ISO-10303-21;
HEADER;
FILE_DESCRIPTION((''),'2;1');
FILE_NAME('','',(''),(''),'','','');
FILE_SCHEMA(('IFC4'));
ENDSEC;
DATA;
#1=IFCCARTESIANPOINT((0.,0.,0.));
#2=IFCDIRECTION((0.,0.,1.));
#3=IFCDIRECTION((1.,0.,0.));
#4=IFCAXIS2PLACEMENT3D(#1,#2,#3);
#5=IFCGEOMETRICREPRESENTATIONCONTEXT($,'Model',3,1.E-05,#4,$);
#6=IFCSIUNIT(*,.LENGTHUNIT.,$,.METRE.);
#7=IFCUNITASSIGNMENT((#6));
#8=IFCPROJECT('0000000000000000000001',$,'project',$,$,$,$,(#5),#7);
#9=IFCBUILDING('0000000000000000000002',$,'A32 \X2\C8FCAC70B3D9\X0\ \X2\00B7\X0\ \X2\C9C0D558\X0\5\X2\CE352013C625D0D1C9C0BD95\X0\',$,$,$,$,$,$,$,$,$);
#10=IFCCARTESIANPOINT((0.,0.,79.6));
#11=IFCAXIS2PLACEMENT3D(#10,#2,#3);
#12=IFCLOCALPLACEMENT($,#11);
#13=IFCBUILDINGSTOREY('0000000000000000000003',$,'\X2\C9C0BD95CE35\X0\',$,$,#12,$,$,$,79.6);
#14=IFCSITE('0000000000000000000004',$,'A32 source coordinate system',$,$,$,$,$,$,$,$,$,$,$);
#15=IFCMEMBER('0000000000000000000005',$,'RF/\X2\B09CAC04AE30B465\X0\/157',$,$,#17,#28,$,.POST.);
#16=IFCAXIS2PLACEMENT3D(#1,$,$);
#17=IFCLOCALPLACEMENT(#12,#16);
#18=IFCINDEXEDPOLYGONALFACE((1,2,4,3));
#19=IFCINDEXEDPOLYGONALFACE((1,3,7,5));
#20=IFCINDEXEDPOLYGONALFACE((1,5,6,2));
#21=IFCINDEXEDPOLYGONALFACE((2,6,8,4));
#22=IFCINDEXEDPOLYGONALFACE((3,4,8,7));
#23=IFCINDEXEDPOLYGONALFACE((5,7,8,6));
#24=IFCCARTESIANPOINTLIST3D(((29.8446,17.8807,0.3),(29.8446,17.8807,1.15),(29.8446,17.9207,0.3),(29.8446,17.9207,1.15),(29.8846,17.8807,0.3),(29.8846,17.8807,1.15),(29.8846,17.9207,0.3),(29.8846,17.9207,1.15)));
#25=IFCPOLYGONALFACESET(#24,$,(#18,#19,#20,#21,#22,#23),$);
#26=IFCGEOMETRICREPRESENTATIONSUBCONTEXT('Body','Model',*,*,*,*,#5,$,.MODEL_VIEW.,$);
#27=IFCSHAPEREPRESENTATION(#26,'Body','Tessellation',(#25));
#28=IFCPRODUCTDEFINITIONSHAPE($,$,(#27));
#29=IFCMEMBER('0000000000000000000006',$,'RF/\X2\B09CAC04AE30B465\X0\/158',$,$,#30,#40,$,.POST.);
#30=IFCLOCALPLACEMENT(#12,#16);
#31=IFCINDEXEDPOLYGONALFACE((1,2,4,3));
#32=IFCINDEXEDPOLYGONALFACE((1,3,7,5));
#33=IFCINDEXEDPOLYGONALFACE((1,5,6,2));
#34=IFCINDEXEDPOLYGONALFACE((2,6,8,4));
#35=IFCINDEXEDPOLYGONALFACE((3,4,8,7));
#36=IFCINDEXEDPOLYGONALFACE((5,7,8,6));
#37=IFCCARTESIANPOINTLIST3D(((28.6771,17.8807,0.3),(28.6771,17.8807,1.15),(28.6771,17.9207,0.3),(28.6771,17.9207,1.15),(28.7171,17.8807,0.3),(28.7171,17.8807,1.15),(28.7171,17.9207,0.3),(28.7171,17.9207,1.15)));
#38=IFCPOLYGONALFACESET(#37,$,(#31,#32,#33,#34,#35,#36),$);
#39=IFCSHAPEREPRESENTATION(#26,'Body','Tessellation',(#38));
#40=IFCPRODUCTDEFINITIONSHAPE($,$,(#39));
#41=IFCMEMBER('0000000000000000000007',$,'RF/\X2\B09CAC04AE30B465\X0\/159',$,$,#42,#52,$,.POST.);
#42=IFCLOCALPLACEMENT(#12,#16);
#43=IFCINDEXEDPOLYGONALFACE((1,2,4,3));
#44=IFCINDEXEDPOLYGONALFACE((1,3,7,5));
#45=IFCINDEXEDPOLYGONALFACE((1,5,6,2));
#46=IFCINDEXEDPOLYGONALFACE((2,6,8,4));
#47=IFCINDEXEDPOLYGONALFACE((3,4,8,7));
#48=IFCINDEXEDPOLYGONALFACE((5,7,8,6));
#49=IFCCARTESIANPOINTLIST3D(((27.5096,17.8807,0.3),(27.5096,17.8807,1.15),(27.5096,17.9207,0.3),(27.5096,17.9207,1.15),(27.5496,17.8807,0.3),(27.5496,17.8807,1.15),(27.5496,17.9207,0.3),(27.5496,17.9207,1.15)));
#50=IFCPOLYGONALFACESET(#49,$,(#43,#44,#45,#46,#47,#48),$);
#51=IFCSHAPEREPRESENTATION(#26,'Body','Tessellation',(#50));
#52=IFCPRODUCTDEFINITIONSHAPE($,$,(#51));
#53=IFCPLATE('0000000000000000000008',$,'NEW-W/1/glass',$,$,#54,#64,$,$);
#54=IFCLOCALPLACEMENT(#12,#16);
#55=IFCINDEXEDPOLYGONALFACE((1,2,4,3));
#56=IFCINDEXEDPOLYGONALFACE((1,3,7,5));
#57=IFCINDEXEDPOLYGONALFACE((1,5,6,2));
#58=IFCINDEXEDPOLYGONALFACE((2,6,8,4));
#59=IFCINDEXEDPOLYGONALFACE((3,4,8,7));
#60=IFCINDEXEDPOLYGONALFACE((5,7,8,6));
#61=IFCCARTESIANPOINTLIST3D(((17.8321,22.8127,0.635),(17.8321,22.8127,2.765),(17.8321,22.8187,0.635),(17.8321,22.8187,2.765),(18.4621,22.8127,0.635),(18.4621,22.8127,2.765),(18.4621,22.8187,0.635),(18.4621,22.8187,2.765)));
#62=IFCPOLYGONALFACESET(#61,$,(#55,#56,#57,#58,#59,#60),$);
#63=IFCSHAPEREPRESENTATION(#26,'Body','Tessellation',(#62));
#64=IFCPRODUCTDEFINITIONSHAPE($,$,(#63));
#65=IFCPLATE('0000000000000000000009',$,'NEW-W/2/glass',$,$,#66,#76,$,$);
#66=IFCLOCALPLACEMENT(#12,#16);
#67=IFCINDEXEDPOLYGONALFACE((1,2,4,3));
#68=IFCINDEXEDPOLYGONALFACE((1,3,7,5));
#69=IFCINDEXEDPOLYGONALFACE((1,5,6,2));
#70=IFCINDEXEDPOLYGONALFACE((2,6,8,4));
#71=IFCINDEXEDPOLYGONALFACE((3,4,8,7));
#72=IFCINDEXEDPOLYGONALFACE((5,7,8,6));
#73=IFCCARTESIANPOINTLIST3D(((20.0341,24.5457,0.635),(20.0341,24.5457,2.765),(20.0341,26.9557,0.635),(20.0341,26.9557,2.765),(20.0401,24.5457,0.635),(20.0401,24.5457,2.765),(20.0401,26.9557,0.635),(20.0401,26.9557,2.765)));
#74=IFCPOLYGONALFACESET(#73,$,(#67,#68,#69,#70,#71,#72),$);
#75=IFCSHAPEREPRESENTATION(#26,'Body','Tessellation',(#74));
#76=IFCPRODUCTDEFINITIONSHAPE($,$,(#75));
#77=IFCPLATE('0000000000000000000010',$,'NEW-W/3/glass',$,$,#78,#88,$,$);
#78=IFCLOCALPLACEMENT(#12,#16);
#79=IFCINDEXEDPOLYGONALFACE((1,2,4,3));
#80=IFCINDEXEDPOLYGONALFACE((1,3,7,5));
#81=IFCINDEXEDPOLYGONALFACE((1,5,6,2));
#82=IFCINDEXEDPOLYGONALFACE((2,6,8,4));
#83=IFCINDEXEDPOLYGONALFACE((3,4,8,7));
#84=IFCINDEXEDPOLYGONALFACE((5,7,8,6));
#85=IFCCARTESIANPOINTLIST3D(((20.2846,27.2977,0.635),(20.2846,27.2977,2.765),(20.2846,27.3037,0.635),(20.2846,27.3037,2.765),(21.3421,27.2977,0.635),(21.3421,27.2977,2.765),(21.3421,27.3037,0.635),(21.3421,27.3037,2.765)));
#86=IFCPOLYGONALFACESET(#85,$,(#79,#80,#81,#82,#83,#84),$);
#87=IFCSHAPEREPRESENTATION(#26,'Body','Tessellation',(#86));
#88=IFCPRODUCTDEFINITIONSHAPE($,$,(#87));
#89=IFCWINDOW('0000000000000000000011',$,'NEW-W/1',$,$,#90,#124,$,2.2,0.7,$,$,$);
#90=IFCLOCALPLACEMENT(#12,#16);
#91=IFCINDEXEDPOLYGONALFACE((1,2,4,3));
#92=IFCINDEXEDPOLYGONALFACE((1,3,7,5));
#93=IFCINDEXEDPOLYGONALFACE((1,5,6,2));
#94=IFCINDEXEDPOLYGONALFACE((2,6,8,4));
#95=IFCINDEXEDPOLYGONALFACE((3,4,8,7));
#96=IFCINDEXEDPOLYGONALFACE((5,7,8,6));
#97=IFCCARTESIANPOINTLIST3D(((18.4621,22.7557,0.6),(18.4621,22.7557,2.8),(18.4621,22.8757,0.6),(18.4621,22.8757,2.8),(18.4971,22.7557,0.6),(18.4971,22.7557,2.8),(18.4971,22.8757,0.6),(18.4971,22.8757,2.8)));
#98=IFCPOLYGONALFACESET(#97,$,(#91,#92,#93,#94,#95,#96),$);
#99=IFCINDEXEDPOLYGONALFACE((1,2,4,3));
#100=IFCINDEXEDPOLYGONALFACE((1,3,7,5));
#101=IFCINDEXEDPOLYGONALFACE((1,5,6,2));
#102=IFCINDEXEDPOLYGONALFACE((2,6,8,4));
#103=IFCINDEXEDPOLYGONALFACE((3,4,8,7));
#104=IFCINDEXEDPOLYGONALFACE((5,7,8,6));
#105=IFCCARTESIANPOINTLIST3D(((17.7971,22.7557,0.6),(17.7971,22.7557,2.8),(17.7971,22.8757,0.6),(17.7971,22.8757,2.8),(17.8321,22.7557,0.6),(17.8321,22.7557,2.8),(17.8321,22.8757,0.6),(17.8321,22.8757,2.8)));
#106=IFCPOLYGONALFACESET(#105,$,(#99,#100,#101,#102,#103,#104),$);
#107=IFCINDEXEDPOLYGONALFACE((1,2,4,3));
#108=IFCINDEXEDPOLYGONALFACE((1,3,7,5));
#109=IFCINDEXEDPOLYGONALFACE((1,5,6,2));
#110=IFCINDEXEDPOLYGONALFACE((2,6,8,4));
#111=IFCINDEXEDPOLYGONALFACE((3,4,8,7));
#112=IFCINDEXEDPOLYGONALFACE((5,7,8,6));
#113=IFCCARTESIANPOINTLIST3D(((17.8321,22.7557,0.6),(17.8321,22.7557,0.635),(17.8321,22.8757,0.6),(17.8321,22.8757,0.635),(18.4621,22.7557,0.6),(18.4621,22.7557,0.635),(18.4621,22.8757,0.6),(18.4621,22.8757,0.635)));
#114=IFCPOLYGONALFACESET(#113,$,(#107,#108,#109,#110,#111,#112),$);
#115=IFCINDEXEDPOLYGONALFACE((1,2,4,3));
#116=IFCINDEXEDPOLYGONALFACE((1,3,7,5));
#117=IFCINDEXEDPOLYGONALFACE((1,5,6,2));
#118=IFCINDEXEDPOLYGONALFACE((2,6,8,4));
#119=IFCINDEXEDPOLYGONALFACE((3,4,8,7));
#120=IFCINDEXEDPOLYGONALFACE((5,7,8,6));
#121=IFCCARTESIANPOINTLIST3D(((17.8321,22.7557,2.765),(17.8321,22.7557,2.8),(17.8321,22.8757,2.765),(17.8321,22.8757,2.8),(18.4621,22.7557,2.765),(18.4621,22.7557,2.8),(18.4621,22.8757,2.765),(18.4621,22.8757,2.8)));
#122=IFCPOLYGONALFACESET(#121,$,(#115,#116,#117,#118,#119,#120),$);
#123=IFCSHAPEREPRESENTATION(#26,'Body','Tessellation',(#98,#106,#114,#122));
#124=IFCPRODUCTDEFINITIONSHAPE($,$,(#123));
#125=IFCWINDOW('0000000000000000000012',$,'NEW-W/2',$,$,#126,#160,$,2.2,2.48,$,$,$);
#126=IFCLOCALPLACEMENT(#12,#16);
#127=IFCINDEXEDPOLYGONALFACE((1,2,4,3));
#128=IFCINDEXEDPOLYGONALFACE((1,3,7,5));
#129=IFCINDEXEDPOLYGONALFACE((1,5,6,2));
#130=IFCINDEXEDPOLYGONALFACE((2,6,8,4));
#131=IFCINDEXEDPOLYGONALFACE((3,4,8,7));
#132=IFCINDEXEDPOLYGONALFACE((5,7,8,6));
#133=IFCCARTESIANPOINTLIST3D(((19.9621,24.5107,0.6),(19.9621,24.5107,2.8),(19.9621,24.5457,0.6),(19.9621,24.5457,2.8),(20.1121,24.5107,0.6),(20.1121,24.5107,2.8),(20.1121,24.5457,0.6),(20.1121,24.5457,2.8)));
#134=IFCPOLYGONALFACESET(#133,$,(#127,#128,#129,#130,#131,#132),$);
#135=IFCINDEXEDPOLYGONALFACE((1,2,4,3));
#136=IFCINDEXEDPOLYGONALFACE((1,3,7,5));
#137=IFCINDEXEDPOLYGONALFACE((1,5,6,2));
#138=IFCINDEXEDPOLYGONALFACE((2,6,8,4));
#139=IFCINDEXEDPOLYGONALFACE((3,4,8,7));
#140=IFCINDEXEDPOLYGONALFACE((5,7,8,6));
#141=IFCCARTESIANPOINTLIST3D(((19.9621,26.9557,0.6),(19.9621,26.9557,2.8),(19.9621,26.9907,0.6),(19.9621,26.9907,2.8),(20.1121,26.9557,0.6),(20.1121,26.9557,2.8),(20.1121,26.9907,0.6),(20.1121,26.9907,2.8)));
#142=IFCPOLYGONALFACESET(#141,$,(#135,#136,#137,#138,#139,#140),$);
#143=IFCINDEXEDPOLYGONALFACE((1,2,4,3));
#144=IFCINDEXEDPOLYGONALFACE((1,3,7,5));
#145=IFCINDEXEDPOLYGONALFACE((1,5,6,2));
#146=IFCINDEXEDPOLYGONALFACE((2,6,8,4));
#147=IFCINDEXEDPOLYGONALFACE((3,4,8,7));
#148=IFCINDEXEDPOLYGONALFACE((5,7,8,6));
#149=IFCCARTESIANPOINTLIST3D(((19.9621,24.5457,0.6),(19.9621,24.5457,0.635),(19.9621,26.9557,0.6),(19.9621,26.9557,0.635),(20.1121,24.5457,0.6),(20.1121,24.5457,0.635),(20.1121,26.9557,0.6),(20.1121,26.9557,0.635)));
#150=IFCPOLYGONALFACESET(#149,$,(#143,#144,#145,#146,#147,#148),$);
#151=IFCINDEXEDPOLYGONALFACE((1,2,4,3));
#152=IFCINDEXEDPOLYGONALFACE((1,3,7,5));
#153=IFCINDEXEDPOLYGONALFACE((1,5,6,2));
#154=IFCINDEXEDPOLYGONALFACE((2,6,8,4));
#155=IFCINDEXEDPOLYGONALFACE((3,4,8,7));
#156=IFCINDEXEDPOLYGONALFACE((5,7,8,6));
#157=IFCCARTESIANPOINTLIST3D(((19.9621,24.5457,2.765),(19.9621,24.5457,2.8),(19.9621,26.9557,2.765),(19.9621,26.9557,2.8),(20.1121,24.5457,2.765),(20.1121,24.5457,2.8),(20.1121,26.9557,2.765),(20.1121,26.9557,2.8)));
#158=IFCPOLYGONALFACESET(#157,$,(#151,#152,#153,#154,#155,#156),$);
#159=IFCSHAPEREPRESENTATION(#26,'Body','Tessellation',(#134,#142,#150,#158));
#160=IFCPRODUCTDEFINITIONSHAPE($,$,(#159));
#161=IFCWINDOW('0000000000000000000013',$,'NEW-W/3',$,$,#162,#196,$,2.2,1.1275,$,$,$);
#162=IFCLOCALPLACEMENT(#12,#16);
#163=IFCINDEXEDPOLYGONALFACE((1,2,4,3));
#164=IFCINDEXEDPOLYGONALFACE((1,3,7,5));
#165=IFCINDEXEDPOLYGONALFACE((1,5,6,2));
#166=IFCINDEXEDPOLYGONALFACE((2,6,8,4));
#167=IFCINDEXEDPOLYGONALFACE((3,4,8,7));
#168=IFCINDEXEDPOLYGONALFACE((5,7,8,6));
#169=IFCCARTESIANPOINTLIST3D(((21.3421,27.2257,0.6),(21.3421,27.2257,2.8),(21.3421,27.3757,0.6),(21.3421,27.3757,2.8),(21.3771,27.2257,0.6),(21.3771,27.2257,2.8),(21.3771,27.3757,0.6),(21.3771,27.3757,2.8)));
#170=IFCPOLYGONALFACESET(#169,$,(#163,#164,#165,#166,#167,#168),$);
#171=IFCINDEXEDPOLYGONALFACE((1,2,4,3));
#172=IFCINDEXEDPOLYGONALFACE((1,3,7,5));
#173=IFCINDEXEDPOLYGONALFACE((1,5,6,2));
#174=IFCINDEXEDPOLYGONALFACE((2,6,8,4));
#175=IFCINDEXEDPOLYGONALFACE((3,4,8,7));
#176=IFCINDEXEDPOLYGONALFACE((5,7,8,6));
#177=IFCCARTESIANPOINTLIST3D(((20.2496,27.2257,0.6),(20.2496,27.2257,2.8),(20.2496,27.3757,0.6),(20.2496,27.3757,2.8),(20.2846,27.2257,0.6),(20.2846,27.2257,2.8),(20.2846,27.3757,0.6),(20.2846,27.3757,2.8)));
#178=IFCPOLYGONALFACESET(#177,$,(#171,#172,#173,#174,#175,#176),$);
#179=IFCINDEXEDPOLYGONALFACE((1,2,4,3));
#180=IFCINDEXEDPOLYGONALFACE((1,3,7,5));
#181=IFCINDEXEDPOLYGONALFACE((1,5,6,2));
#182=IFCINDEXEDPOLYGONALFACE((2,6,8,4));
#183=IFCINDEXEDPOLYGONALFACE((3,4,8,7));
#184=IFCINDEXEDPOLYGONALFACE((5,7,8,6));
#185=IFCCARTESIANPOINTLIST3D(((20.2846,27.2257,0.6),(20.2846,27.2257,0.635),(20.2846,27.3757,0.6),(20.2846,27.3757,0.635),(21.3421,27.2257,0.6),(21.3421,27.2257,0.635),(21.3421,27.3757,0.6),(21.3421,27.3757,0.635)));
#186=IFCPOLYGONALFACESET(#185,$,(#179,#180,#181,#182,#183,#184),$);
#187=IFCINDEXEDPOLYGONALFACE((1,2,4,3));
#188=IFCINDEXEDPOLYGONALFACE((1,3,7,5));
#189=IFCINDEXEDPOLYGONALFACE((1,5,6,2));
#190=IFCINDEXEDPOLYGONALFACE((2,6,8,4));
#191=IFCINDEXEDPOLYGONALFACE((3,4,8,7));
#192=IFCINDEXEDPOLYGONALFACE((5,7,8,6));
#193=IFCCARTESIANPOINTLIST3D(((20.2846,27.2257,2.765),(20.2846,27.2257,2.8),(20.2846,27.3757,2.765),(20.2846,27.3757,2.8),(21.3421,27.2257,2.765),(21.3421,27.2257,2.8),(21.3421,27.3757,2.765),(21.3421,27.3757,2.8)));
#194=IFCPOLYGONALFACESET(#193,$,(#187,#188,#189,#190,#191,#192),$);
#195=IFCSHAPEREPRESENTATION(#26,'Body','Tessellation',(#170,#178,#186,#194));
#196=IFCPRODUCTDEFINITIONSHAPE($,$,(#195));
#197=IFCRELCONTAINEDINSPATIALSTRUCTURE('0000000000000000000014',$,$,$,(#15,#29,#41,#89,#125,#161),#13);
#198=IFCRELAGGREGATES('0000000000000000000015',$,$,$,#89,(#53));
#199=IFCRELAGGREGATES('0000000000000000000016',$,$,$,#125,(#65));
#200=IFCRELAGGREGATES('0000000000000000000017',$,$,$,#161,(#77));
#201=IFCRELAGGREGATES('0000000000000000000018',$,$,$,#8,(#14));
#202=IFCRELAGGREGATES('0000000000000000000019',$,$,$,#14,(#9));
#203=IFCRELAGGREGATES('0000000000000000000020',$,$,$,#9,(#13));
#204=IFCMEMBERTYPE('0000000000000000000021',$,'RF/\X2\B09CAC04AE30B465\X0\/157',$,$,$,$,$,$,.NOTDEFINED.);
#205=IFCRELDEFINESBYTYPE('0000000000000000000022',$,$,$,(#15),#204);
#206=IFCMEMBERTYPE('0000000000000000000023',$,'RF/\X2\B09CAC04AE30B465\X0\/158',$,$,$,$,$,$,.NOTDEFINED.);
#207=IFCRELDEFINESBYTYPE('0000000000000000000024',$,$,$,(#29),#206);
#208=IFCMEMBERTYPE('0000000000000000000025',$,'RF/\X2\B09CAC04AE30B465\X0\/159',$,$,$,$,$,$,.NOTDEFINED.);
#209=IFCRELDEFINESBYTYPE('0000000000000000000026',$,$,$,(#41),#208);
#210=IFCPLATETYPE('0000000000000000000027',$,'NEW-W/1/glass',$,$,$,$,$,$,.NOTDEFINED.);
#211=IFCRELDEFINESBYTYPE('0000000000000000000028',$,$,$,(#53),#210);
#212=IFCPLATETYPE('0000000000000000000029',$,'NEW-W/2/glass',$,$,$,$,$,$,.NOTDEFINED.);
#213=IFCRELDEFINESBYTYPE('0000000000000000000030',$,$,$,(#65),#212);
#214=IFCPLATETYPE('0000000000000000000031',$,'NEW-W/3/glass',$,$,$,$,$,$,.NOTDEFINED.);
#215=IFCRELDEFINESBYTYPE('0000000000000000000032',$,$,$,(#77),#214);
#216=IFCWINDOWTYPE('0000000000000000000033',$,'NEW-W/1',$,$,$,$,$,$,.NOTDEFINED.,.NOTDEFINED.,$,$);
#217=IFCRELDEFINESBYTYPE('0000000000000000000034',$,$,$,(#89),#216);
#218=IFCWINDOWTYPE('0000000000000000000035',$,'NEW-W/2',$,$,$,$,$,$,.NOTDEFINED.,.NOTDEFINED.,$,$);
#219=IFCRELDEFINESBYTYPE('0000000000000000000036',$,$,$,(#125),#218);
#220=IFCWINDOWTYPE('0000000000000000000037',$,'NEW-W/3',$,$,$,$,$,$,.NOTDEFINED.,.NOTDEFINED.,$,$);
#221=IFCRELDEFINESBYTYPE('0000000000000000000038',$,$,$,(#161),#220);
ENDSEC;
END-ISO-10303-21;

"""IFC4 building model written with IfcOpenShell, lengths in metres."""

from ifc_helpers import new_model, si_unit, frame, origin, origin_with_axes, place, context, subcontext, project, spatial, polyline, outline, extrude, source, transform, mapped, type_object, type_shapes, element, aggregate, save


model = new_model("IFC4")

# Units and contexts
model_context = context("Model", 3, precision=1e-05, world=origin_with_axes())
body_context = subcontext(model_context, "Body", "Model", "MODEL_VIEW")
ifc_project = project(units=[si_unit("LENGTHUNIT", "METRE")], contexts=[model_context])

# Site, building, storey
site = spatial("IfcSite", under=ifc_project, Name="A32 source coordinate system")
building = spatial("IfcBuilding", under=site, Name="A32 주거동 · 지하5층–옥탑지붕")
storey_placement = place(None, frame((0.0, 0.0, 79.6), z_axis=(0.0, 0.0, 1.0), x_axis=(1.0, 0.0, 0.0)))
storey = spatial("IfcBuildingStorey", under=building, at=storey_placement, Name="지붕층", Elevation=79.6)

# Members
member_type_1 = type_object("IfcMemberType", Name="RF/난간기둥/157", PredefinedType="NOTDEFINED")
shared_shape_1 = source(origin(), body_context, "Body", "SweptSolid", [
    extrude(outline(polyline([(29.8846, 17.8807), (29.8446, 17.8807), (29.8446, 17.9207), (29.8846, 17.9207), (29.8846, 17.8807)])), frame((0.0, 0.0, 0.3)), (0.0, 0.0, 1.0), 0.85),
])
type_shapes(member_type_1, [shared_shape_1])
member_1_placement = place(storey_placement, origin_with_axes())
element("IfcMember", 1, at=member_1_placement, inside=storey, type_object=member_type_1, Name="RF/난간기둥/157", PredefinedType="POST", context=body_context, shape_type="MappedRepresentation", body=[
    mapped(shared_shape_1, transform((0.0, 0.0, 0.0), scale=1.0)),
])
member_type_2 = type_object("IfcMemberType", Name="RF/난간기둥/158", PredefinedType="NOTDEFINED")
shared_shape_2 = source(origin(), body_context, "Body", "SweptSolid", [
    extrude(outline(polyline([(28.7171, 17.8807), (28.6771, 17.8807), (28.6771, 17.9207), (28.7171, 17.9207), (28.7171, 17.8807)])), frame((0.0, 0.0, 0.3)), (0.0, 0.0, 1.0), 0.85),
])
type_shapes(member_type_2, [shared_shape_2])
member_2_placement = place(storey_placement, origin_with_axes())
element("IfcMember", 2, at=member_2_placement, inside=storey, type_object=member_type_2, Name="RF/난간기둥/158", PredefinedType="POST", context=body_context, shape_type="MappedRepresentation", body=[
    mapped(shared_shape_2, transform((0.0, 0.0, 0.0), scale=1.0)),
])
member_type_3 = type_object("IfcMemberType", Name="RF/난간기둥/159", PredefinedType="NOTDEFINED")
shared_shape_3 = source(origin(), body_context, "Body", "SweptSolid", [
    extrude(outline(polyline([(27.5496, 17.8807), (27.5096, 17.8807), (27.5096, 17.9207), (27.5496, 17.9207), (27.5496, 17.8807)])), frame((0.0, 0.0, 0.3)), (0.0, 0.0, 1.0), 0.85),
])
type_shapes(member_type_3, [shared_shape_3])
member_3_placement = place(storey_placement, origin_with_axes())
element("IfcMember", 3, at=member_3_placement, inside=storey, type_object=member_type_3, Name="RF/난간기둥/159", PredefinedType="POST", context=body_context, shape_type="MappedRepresentation", body=[
    mapped(shared_shape_3, transform((0.0, 0.0, 0.0), scale=1.0)),
])

# Plates
plate_type_1 = type_object("IfcPlateType", Name="NEW-W/1/glass", PredefinedType="NOTDEFINED")
shared_shape_4 = source(origin(), body_context, "Body", "SweptSolid", [
    extrude(outline(polyline([(18.4621, 22.8127), (17.8321, 22.8127), (17.8321, 22.8187), (18.4621, 22.8187), (18.4621, 22.8127)])), frame((0.0, 0.0, 0.635)), (0.0, 0.0, 1.0), 2.13),
])
type_shapes(plate_type_1, [shared_shape_4])
window_1_placement = place(storey_placement, origin_with_axes())
plate_1_placement = place(window_1_placement, origin_with_axes())
plate_1 = element("IfcPlate", 4, at=plate_1_placement, type_object=plate_type_1, Name="NEW-W/1/glass", context=body_context, shape_type="MappedRepresentation", body=[
    mapped(shared_shape_4, transform((0.0, 0.0, 0.0), scale=1.0)),
])
plate_type_2 = type_object("IfcPlateType", Name="NEW-W/2/glass", PredefinedType="NOTDEFINED")
shared_shape_5 = source(origin(), body_context, "Body", "SweptSolid", [
    extrude(outline(polyline([(20.0401, 24.5457), (20.0341, 24.5457), (20.0341, 26.9557), (20.0401, 26.9557), (20.0401, 24.5457)])), frame((0.0, 0.0, 0.635)), (0.0, 0.0, 1.0), 2.13),
])
type_shapes(plate_type_2, [shared_shape_5])
window_2_placement = place(storey_placement, origin_with_axes())
plate_2_placement = place(window_2_placement, origin_with_axes())
plate_2 = element("IfcPlate", 5, at=plate_2_placement, type_object=plate_type_2, Name="NEW-W/2/glass", context=body_context, shape_type="MappedRepresentation", body=[
    mapped(shared_shape_5, transform((0.0, 0.0, 0.0), scale=1.0)),
])
plate_type_3 = type_object("IfcPlateType", Name="NEW-W/3/glass", PredefinedType="NOTDEFINED")
shared_shape_6 = source(origin(), body_context, "Body", "SweptSolid", [
    extrude(outline(polyline([(21.3421, 27.2977), (20.2846, 27.2977), (20.2846, 27.3037), (21.3421, 27.3037), (21.3421, 27.2977)])), frame((0.0, 0.0, 0.635)), (0.0, 0.0, 1.0), 2.13),
])
type_shapes(plate_type_3, [shared_shape_6])
window_3_placement = place(storey_placement, origin_with_axes())
plate_3_placement = place(window_3_placement, origin_with_axes())
plate_3 = element("IfcPlate", 6, at=plate_3_placement, type_object=plate_type_3, Name="NEW-W/3/glass", context=body_context, shape_type="MappedRepresentation", body=[
    mapped(shared_shape_6, transform((0.0, 0.0, 0.0), scale=1.0)),
])

# Windows
window_type_1 = type_object("IfcWindowType", Name="NEW-W/1", PartitioningType="NOTDEFINED", PredefinedType="NOTDEFINED")
shared_shape_7 = source(origin(), body_context, "Body", "SweptSolid", [
    extrude(outline(polyline([(18.4621, 22.7557), (18.4621, 22.8757), (18.4971, 22.8757), (18.4971, 22.7557), (18.4621, 22.7557)])), frame((0.0, 0.0, 0.6)), (0.0, 0.0, 1.0), 2.2),
    extrude(outline(polyline([(17.7971, 22.7557), (17.7971, 22.8757), (17.8321, 22.8757), (17.8321, 22.7557), (17.7971, 22.7557)])), frame((0.0, 0.0, 0.6)), (0.0, 0.0, 1.0), 2.2),
    extrude(outline(polyline([(18.4621, 22.7557), (18.4621, 22.8757), (17.8321, 22.8757), (17.8321, 22.7557), (18.4621, 22.7557)])), frame((0.0, 0.0, 0.6)), (0.0, 0.0, 1.0), 0.035),
    extrude(outline(polyline([(18.4621, 22.7557), (18.4621, 22.8757), (17.8321, 22.8757), (17.8321, 22.7557), (18.4621, 22.7557)])), frame((0.0, 0.0, 2.765)), (0.0, 0.0, 1.0), 0.035),
])
type_shapes(window_type_1, [shared_shape_7])
window_1 = element("IfcWindow", 7, at=window_1_placement, inside=storey, type_object=window_type_1, Name="NEW-W/1", OverallHeight=2.2, OverallWidth=0.7, context=body_context, shape_type="MappedRepresentation", body=[
    mapped(shared_shape_7, transform((0.0, 0.0, 0.0), scale=1.0)),
])
aggregate(window_1, [plate_1])
window_type_2 = type_object("IfcWindowType", Name="NEW-W/2", PartitioningType="NOTDEFINED", PredefinedType="NOTDEFINED")
shared_shape_8 = source(origin(), body_context, "Body", "SweptSolid", [
    extrude(outline(polyline([(19.9621, 24.5107), (19.9621, 24.5457), (20.1121, 24.5457), (20.1121, 24.5107), (19.9621, 24.5107)])), frame((0.0, 0.0, 0.6)), (0.0, 0.0, 1.0), 2.2),
    extrude(outline(polyline([(19.9621, 26.9557), (19.9621, 26.9907), (20.1121, 26.9907), (20.1121, 26.9557), (19.9621, 26.9557)])), frame((0.0, 0.0, 0.6)), (0.0, 0.0, 1.0), 2.2),
    extrude(outline(polyline([(20.1121, 24.5457), (20.1121, 26.9557), (19.9621, 26.9557), (19.9621, 24.5457), (20.1121, 24.5457)])), frame((0.0, 0.0, 0.6)), (0.0, 0.0, 1.0), 0.035),
    extrude(outline(polyline([(20.1121, 24.5457), (20.1121, 26.9557), (19.9621, 26.9557), (19.9621, 24.5457), (20.1121, 24.5457)])), frame((0.0, 0.0, 2.765)), (0.0, 0.0, 1.0), 0.035),
])
type_shapes(window_type_2, [shared_shape_8])
window_2 = element("IfcWindow", 8, at=window_2_placement, inside=storey, type_object=window_type_2, Name="NEW-W/2", OverallHeight=2.2, OverallWidth=2.48, context=body_context, shape_type="MappedRepresentation", body=[
    mapped(shared_shape_8, transform((0.0, 0.0, 0.0), scale=1.0)),
])
aggregate(window_2, [plate_2])
window_type_3 = type_object("IfcWindowType", Name="NEW-W/3", PartitioningType="NOTDEFINED", PredefinedType="NOTDEFINED")
shared_shape_9 = source(origin(), body_context, "Body", "SweptSolid", [
    extrude(outline(polyline([(21.3421, 27.2257), (21.3421, 27.3757), (21.3771, 27.3757), (21.3771, 27.2257), (21.3421, 27.2257)])), frame((0.0, 0.0, 0.6)), (0.0, 0.0, 1.0), 2.2),
    extrude(outline(polyline([(20.2496, 27.2257), (20.2496, 27.3757), (20.2846, 27.3757), (20.2846, 27.2257), (20.2496, 27.2257)])), frame((0.0, 0.0, 0.6)), (0.0, 0.0, 1.0), 2.2),
    extrude(outline(polyline([(21.3421, 27.2257), (21.3421, 27.3757), (20.2846, 27.3757), (20.2846, 27.2257), (21.3421, 27.2257)])), frame((0.0, 0.0, 0.6)), (0.0, 0.0, 1.0), 0.035),
    extrude(outline(polyline([(21.3421, 27.2257), (21.3421, 27.3757), (20.2846, 27.3757), (20.2846, 27.2257), (21.3421, 27.2257)])), frame((0.0, 0.0, 2.765)), (0.0, 0.0, 1.0), 0.035),
])
type_shapes(window_type_3, [shared_shape_9])
window_3 = element("IfcWindow", 9, at=window_3_placement, inside=storey, type_object=window_type_3, Name="NEW-W/3", OverallHeight=2.2, OverallWidth=1.1275, context=body_context, shape_type="MappedRepresentation", body=[
    mapped(shared_shape_9, transform((0.0, 0.0, 0.0), scale=1.0)),
])
aggregate(window_3, [plate_3])

save(model, "model.ifc")
